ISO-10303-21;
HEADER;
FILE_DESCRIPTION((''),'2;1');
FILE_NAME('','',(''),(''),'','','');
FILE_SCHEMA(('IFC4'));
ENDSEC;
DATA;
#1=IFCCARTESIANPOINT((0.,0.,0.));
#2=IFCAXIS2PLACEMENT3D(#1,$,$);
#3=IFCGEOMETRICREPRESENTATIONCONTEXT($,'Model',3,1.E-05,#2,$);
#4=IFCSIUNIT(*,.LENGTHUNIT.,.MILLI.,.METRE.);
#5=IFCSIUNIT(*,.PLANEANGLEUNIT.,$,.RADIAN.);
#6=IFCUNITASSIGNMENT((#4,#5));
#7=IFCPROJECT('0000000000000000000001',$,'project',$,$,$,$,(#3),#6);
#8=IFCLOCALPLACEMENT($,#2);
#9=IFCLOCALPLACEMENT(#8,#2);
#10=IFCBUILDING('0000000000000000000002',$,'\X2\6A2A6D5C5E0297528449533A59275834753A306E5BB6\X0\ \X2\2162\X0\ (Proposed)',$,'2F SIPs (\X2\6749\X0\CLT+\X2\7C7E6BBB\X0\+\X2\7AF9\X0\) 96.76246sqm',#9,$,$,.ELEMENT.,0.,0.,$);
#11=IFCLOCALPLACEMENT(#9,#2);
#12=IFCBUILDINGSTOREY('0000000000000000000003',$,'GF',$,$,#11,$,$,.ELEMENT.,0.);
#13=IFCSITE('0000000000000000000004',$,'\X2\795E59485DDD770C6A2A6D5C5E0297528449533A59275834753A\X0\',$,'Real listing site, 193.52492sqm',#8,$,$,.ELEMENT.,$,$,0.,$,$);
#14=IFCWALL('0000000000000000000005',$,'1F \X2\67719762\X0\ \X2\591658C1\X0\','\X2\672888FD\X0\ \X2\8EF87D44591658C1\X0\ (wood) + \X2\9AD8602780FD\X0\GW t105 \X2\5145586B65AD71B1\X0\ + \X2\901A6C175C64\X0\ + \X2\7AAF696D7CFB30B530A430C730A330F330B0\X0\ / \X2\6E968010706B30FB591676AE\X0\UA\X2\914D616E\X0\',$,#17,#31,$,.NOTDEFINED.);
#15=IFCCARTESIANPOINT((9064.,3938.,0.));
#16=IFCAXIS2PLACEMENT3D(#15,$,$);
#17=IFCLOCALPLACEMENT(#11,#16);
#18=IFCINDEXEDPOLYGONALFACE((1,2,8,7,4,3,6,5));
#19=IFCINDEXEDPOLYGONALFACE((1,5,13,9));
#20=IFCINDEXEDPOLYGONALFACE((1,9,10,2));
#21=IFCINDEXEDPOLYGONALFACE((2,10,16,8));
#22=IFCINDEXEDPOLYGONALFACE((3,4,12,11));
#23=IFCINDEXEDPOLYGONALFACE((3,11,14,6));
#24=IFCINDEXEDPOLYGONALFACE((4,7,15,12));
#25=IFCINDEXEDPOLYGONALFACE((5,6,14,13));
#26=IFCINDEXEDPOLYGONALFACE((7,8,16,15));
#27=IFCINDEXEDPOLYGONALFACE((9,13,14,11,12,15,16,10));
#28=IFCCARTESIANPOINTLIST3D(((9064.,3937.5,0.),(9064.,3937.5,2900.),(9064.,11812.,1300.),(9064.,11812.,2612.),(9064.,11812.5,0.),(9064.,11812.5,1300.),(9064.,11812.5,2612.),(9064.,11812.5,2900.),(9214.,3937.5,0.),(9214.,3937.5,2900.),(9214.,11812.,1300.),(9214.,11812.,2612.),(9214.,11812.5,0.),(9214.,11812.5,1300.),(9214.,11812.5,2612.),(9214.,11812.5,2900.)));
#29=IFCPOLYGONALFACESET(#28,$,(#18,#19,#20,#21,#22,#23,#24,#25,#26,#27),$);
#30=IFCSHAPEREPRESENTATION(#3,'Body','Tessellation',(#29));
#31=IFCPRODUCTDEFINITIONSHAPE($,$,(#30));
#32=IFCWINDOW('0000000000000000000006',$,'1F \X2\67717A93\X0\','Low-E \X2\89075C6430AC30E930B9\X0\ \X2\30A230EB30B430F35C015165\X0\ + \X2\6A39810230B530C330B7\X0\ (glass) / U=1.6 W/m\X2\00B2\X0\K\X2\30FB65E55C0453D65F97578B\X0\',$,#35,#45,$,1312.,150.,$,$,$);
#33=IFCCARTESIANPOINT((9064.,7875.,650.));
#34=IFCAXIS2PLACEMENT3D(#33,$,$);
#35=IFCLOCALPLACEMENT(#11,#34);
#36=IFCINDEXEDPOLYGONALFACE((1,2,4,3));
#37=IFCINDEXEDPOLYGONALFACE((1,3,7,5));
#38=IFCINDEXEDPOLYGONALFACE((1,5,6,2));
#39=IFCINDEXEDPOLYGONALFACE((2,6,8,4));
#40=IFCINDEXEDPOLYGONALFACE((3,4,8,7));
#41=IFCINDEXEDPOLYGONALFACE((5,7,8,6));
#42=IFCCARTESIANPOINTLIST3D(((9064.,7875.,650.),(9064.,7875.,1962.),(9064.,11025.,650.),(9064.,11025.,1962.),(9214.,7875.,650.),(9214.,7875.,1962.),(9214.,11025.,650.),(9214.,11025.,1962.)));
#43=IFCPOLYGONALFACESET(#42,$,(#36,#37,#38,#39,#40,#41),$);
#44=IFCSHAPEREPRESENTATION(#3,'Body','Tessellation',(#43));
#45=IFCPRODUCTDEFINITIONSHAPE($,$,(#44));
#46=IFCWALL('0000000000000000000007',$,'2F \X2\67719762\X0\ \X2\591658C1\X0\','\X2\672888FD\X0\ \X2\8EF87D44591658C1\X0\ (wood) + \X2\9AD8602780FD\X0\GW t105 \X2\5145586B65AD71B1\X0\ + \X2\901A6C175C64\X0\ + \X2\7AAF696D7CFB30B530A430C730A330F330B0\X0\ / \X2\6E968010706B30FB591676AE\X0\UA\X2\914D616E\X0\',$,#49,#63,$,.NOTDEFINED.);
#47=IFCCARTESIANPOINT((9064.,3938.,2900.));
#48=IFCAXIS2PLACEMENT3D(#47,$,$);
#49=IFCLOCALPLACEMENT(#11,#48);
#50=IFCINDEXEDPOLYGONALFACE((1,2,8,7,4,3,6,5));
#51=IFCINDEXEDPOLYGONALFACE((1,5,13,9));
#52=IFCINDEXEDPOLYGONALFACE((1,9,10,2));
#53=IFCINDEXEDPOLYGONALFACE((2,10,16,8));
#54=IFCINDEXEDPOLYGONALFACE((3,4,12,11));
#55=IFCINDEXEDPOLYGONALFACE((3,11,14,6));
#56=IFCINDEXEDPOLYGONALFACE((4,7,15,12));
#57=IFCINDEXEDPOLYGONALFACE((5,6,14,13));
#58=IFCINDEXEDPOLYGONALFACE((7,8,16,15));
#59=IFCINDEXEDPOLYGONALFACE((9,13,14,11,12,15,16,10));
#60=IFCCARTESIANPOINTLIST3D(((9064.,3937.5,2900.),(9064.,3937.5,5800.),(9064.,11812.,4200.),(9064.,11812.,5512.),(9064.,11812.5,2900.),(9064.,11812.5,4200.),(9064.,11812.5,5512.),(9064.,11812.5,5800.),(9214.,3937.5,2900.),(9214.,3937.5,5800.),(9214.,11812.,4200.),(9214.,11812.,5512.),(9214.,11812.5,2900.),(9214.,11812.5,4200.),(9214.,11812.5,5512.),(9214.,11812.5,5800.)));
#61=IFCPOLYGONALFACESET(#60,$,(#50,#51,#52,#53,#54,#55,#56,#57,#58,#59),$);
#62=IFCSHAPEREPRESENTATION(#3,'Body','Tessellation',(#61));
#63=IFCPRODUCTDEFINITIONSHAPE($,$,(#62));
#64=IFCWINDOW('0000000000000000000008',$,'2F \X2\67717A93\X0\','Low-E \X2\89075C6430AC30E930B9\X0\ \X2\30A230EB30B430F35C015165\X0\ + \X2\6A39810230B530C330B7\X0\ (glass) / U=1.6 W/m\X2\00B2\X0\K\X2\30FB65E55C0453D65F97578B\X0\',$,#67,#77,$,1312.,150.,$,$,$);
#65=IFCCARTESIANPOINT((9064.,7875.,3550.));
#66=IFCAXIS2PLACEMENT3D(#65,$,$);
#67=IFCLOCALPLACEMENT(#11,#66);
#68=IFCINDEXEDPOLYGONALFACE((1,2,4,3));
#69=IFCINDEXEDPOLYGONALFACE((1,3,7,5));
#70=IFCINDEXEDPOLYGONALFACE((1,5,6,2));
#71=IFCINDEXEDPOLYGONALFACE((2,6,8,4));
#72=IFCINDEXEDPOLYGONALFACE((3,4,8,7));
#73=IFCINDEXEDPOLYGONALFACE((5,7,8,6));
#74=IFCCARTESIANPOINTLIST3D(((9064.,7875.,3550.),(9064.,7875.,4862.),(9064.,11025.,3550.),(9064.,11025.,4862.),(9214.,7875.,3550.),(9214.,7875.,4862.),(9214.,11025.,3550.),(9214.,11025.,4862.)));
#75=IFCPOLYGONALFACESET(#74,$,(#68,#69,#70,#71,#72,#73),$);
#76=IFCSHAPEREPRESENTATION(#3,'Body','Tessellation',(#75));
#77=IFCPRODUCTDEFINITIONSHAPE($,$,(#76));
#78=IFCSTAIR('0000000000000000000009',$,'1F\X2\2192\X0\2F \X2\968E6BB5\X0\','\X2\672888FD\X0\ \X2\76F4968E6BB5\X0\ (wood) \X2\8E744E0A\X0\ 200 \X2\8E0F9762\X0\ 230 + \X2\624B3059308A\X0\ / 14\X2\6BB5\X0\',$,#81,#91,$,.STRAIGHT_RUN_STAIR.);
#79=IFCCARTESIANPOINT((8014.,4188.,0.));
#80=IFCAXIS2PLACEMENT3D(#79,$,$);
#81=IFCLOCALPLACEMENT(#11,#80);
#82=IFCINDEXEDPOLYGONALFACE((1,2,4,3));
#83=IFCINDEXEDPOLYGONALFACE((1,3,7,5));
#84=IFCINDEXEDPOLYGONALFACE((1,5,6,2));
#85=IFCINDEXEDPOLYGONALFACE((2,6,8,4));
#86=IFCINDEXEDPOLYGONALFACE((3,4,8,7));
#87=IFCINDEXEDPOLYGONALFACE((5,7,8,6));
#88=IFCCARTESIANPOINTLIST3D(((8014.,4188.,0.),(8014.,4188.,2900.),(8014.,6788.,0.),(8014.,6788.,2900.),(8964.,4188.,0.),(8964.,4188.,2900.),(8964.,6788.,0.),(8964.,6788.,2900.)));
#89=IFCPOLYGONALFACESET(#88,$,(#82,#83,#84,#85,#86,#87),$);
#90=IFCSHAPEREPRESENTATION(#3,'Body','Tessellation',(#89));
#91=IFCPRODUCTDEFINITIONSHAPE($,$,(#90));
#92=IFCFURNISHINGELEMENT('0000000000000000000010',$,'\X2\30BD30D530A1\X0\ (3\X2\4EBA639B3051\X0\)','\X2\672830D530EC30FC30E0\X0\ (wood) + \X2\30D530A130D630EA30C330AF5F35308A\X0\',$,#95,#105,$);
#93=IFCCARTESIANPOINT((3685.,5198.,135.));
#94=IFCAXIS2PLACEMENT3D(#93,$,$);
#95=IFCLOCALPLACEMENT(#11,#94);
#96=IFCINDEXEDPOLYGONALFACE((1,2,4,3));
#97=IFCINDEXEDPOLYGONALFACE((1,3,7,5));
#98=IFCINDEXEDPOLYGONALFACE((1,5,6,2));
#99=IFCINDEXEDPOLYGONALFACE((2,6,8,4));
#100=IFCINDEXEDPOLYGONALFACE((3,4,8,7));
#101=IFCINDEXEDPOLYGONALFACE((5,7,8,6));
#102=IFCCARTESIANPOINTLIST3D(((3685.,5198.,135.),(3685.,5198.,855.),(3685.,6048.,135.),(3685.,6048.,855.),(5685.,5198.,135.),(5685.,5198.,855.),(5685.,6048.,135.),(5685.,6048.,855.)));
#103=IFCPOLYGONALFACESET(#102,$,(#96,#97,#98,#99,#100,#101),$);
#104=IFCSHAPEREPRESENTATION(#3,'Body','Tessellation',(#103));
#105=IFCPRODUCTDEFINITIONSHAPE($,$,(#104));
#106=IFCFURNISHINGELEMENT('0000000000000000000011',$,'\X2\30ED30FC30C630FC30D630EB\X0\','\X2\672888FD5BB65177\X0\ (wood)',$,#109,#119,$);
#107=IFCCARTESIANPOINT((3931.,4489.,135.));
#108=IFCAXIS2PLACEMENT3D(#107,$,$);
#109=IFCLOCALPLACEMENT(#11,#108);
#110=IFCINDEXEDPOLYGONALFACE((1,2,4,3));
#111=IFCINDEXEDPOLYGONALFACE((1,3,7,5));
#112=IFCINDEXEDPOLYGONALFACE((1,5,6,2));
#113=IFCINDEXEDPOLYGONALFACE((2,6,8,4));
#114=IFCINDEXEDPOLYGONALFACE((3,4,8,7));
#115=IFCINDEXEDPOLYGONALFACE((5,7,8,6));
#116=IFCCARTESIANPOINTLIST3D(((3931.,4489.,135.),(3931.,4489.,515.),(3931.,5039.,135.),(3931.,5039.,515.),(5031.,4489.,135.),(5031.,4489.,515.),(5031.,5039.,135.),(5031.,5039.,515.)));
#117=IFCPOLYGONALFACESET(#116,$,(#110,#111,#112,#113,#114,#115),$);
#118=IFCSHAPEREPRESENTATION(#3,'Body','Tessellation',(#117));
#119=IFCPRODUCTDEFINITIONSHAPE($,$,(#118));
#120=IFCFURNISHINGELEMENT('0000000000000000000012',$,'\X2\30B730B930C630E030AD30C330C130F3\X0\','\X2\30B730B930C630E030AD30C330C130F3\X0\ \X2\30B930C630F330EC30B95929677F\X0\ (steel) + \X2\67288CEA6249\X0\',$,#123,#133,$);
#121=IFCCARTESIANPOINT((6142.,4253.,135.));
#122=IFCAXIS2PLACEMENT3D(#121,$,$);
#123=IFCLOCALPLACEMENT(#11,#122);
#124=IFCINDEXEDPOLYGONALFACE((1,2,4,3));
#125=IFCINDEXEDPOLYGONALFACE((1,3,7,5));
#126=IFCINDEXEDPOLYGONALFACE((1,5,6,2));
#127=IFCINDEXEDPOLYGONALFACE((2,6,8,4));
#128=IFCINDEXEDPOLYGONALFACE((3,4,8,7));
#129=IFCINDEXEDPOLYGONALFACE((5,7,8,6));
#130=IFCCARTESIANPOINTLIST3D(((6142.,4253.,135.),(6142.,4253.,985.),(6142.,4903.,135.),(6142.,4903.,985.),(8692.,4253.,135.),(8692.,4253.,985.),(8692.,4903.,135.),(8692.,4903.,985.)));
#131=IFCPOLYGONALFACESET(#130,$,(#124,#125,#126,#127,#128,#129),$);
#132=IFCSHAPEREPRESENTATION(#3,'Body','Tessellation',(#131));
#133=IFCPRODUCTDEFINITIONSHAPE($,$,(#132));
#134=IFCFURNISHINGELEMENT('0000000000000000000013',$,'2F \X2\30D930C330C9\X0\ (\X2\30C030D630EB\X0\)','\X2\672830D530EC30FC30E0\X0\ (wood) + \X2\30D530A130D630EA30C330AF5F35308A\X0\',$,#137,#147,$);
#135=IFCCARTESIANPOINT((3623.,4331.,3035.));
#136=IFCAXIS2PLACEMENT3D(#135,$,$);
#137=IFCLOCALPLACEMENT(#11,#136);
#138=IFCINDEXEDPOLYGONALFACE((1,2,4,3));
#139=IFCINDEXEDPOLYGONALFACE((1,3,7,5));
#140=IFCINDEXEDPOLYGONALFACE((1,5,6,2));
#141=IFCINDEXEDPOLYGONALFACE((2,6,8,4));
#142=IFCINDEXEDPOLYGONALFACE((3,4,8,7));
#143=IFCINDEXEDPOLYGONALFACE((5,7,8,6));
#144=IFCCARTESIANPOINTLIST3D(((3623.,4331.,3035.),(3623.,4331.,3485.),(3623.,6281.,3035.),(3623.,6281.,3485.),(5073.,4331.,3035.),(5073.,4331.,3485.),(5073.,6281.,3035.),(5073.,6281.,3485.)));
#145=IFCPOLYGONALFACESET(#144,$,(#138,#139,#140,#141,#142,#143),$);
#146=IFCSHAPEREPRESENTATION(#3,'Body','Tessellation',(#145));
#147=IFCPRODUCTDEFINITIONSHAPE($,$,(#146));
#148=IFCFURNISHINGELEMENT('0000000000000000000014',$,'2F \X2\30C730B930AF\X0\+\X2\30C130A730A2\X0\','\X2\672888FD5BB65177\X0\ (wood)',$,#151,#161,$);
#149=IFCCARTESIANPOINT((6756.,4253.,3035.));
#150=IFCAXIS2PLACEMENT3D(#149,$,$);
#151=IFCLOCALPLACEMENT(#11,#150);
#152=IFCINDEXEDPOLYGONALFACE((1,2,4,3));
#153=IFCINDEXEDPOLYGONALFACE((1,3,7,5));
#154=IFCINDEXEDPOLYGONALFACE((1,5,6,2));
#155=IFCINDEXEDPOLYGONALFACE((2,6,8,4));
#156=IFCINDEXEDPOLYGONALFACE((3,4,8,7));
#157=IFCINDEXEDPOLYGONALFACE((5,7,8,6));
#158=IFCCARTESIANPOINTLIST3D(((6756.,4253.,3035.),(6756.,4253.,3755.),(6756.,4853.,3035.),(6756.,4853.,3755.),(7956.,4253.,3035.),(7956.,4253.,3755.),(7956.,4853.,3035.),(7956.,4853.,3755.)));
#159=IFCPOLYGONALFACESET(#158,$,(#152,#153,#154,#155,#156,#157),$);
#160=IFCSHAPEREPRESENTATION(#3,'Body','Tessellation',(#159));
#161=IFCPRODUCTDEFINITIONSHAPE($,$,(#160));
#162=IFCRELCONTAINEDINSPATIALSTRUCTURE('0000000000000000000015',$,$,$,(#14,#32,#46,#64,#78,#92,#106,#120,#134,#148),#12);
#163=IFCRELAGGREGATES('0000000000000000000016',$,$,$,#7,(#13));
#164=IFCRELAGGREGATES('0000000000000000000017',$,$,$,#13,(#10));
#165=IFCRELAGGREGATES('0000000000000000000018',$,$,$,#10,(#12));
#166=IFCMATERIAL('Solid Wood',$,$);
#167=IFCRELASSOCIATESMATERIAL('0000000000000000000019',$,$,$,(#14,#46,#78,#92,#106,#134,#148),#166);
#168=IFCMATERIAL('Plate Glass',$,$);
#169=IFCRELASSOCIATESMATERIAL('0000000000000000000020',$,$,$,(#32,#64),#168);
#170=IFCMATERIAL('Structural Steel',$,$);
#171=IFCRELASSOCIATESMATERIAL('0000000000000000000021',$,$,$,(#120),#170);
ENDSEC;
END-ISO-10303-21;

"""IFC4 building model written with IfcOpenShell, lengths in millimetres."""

from ifc_helpers import new_model, si_unit, frame, frame_2d, origin, place, context, project, spatial, rectangle, extrude, material, element, fill, save


model = new_model("IFC4")

# Units and contexts
model_context = context("Model", 3, precision=1e-05, world=origin())
ifc_project = project(units=[si_unit("LENGTHUNIT", "METRE", prefix="MILLI"), si_unit("PLANEANGLEUNIT", "RADIAN")], contexts=[model_context])

# Site, building, storey
site_placement = place(None, origin())
site = spatial("IfcSite", under=ifc_project, at=site_placement, Name="神奈川県横浜市青葉区大場町", ObjectType="Real listing site, 193.52492sqm", CompositionType="ELEMENT", RefElevation=0.0)
building_placement = place(site_placement, origin())
building = spatial("IfcBuilding", under=site, at=building_placement, Name="横浜市青葉区大場町の家 Ⅲ (Proposed)", ObjectType="2F SIPs (杉CLT+籾殻+竹) 96.76246sqm", CompositionType="ELEMENT", ElevationOfRefHeight=0.0, ElevationOfTerrain=0.0)
storey_placement = place(building_placement, origin())
storey = spatial("IfcBuildingStorey", under=building, at=storey_placement, Name="GF", CompositionType="ELEMENT", Elevation=0.0)

# Wall, opening, window
ifc_material_1 = material(Name="Solid Wood")
wall_1_placement = place(storey_placement, frame((9064.0, 3938.0, 0.0)))
wall_1 = element("IfcWall", 1, at=wall_1_placement, inside=storey, material=ifc_material_1, Name="1F 東面 外壁", Description="木製 軸組外壁 (wood) + 高性能GW t105 充填断熱 + 通気層 + 窯業系サイディング / 準耐火・外皮UA配慮", PredefinedType="NOTDEFINED", context=model_context, shape_type="SweptSolid", body=[
    extrude(rectangle(XDim=150.0, YDim=7875.0, at=frame_2d((75.0, 3937.0))), frame((9064.0, 3938.0, 0.0)), (0.0, 0.0, 1.0), 2900.0),
])
opening_1_placement = place(storey_placement, frame((9064.0, 7875.0, 650.0)))
opening_1 = element("IfcOpeningElement", 2, at=opening_1_placement, cuts=wall_1, PredefinedType="NOTDEFINED", context=model_context, shape_type="SweptSolid", body=[
    extrude(rectangle(XDim=150.0, YDim=3150.0, at=frame_2d((75.0, 1575.0))), frame((9064.0, 7875.0, 650.0)), (0.0, 0.0, 1.0), 1312.0),
])
ifc_material_2 = material(Name="Plate Glass")
window_1_placement = place(storey_placement, frame((9064.0, 7875.0, 650.0)))
window_1 = element("IfcWindow", 3, at=window_1_placement, inside=storey, material=ifc_material_2, Name="1F 東窓", Description="Low-E 複層ガラス アルゴン封入 + 樹脂サッシ (glass) / U=1.6 W/m²K・日射取得型", OverallHeight=1312.0, OverallWidth=150.0, context=model_context, shape_type="SweptSolid", body=[
    extrude(rectangle(XDim=150.0, YDim=3150.0, at=frame_2d((75.0, 1575.0))), frame((9064.0, 7875.0, 650.0)), (0.0, 0.0, 1.0), 1312.0),
])
fill(opening_1, window_1)

# Wall, opening, window
wall_2_placement = place(storey_placement, frame((9064.0, 3938.0, 2900.0)))
wall_2 = element("IfcWall", 4, at=wall_2_placement, inside=storey, material=ifc_material_1, Name="2F 東面 外壁", Description="木製 軸組外壁 (wood) + 高性能GW t105 充填断熱 + 通気層 + 窯業系サイディング / 準耐火・外皮UA配慮", PredefinedType="NOTDEFINED", context=model_context, shape_type="SweptSolid", body=[
    extrude(rectangle(XDim=150.0, YDim=7875.0, at=frame_2d((75.0, 3937.0))), frame((9064.0, 3938.0, 2900.0)), (0.0, 0.0, 1.0), 2900.0),
])
opening_2_placement = place(storey_placement, frame((9064.0, 7875.0, 3550.0)))
opening_2 = element("IfcOpeningElement", 5, at=opening_2_placement, cuts=wall_2, PredefinedType="NOTDEFINED", context=model_context, shape_type="SweptSolid", body=[
    extrude(rectangle(XDim=150.0, YDim=3150.0, at=frame_2d((75.0, 1575.0))), frame((9064.0, 7875.0, 3550.0)), (0.0, 0.0, 1.0), 1312.0),
])
window_2_placement = place(storey_placement, frame((9064.0, 7875.0, 3550.0)))
window_2 = element("IfcWindow", 6, at=window_2_placement, inside=storey, material=ifc_material_2, Name="2F 東窓", Description="Low-E 複層ガラス アルゴン封入 + 樹脂サッシ (glass) / U=1.6 W/m²K・日射取得型", OverallHeight=1312.0, OverallWidth=150.0, context=model_context, shape_type="SweptSolid", body=[
    extrude(rectangle(XDim=150.0, YDim=3150.0, at=frame_2d((75.0, 1575.0))), frame((9064.0, 7875.0, 3550.0)), (0.0, 0.0, 1.0), 1312.0),
])
fill(opening_2, window_2)

# Stair
stair_placement = place(storey_placement, frame((8014.0, 4188.0, 0.0)))
element("IfcStair", 7, at=stair_placement, inside=storey, material=ifc_material_1, Name="1F→2F 階段", Description="木製 直階段 (wood) 蹴上 200 踏面 230 + 手すり / 14段", PredefinedType="STRAIGHT_RUN_STAIR", context=model_context, shape_type="SweptSolid", body=[
    extrude(rectangle(XDim=950.0, YDim=2600.0, at=frame_2d((475.0, 1300.0))), frame((8014.0, 4188.0, 0.0)), (0.0, 0.0, 1.0), 2900.0),
])

# Furnishing elements
furnishing_1_placement = place(storey_placement, frame((3685.0, 5198.0, 135.0)))
element("IfcFurnishingElement", 8, at=furnishing_1_placement, inside=storey, material=ifc_material_1, Name="ソファ (3人掛け)", Description="木フレーム (wood) + ファブリック張り", context=model_context, shape_type="SweptSolid", body=[
    extrude(rectangle(XDim=2000.0, YDim=850.0, at=frame_2d((1000.0, 425.0))), frame((3685.0, 5198.0, 135.0)), (0.0, 0.0, 1.0), 720.0),
])
furnishing_2_placement = place(storey_placement, frame((3931.0, 4489.0, 135.0)))
element("IfcFurnishingElement", 9, at=furnishing_2_placement, inside=storey, material=ifc_material_1, Name="ローテーブル", Description="木製家具 (wood)", context=model_context, shape_type="SweptSolid", body=[
    extrude(rectangle(XDim=1100.0, YDim=550.0, at=frame_2d((550.0, 275.0))), frame((3931.0, 4489.0, 135.0)), (0.0, 0.0, 1.0), 380.0),
])
ifc_material_3 = material(Name="Structural Steel")
furnishing_3_placement = place(storey_placement, frame((6142.0, 4253.0, 135.0)))
element("IfcFurnishingElement", 10, at=furnishing_3_placement, inside=storey, material=ifc_material_3, Name="システムキッチン", Description="システムキッチン ステンレス天板 (steel) + 木質扉", context=model_context, shape_type="SweptSolid", body=[
    extrude(rectangle(XDim=2550.0, YDim=650.0, at=frame_2d((1275.0, 325.0))), frame((6142.0, 4253.0, 135.0)), (0.0, 0.0, 1.0), 850.0),
])
furnishing_4_placement = place(storey_placement, frame((3623.0, 4331.0, 3035.0)))
element("IfcFurnishingElement", 11, at=furnishing_4_placement, inside=storey, material=ifc_material_1, Name="2F ベッド (ダブル)", Description="木フレーム (wood) + ファブリック張り", context=model_context, shape_type="SweptSolid", body=[
    extrude(rectangle(XDim=1450.0, YDim=1950.0, at=frame_2d((725.0, 975.0))), frame((3623.0, 4331.0, 3035.0)), (0.0, 0.0, 1.0), 450.0),
])
furnishing_5_placement = place(storey_placement, frame((6756.0, 4253.0, 3035.0)))
element("IfcFurnishingElement", 12, at=furnishing_5_placement, inside=storey, material=ifc_material_1, Name="2F デスク+チェア", Description="木製家具 (wood)", context=model_context, shape_type="SweptSolid", body=[
    extrude(rectangle(XDim=1200.0, YDim=600.0, at=frame_2d((600.0, 300.0))), frame((6756.0, 4253.0, 3035.0)), (0.0, 0.0, 1.0), 720.0),
])

save(model, "model.ifc")
